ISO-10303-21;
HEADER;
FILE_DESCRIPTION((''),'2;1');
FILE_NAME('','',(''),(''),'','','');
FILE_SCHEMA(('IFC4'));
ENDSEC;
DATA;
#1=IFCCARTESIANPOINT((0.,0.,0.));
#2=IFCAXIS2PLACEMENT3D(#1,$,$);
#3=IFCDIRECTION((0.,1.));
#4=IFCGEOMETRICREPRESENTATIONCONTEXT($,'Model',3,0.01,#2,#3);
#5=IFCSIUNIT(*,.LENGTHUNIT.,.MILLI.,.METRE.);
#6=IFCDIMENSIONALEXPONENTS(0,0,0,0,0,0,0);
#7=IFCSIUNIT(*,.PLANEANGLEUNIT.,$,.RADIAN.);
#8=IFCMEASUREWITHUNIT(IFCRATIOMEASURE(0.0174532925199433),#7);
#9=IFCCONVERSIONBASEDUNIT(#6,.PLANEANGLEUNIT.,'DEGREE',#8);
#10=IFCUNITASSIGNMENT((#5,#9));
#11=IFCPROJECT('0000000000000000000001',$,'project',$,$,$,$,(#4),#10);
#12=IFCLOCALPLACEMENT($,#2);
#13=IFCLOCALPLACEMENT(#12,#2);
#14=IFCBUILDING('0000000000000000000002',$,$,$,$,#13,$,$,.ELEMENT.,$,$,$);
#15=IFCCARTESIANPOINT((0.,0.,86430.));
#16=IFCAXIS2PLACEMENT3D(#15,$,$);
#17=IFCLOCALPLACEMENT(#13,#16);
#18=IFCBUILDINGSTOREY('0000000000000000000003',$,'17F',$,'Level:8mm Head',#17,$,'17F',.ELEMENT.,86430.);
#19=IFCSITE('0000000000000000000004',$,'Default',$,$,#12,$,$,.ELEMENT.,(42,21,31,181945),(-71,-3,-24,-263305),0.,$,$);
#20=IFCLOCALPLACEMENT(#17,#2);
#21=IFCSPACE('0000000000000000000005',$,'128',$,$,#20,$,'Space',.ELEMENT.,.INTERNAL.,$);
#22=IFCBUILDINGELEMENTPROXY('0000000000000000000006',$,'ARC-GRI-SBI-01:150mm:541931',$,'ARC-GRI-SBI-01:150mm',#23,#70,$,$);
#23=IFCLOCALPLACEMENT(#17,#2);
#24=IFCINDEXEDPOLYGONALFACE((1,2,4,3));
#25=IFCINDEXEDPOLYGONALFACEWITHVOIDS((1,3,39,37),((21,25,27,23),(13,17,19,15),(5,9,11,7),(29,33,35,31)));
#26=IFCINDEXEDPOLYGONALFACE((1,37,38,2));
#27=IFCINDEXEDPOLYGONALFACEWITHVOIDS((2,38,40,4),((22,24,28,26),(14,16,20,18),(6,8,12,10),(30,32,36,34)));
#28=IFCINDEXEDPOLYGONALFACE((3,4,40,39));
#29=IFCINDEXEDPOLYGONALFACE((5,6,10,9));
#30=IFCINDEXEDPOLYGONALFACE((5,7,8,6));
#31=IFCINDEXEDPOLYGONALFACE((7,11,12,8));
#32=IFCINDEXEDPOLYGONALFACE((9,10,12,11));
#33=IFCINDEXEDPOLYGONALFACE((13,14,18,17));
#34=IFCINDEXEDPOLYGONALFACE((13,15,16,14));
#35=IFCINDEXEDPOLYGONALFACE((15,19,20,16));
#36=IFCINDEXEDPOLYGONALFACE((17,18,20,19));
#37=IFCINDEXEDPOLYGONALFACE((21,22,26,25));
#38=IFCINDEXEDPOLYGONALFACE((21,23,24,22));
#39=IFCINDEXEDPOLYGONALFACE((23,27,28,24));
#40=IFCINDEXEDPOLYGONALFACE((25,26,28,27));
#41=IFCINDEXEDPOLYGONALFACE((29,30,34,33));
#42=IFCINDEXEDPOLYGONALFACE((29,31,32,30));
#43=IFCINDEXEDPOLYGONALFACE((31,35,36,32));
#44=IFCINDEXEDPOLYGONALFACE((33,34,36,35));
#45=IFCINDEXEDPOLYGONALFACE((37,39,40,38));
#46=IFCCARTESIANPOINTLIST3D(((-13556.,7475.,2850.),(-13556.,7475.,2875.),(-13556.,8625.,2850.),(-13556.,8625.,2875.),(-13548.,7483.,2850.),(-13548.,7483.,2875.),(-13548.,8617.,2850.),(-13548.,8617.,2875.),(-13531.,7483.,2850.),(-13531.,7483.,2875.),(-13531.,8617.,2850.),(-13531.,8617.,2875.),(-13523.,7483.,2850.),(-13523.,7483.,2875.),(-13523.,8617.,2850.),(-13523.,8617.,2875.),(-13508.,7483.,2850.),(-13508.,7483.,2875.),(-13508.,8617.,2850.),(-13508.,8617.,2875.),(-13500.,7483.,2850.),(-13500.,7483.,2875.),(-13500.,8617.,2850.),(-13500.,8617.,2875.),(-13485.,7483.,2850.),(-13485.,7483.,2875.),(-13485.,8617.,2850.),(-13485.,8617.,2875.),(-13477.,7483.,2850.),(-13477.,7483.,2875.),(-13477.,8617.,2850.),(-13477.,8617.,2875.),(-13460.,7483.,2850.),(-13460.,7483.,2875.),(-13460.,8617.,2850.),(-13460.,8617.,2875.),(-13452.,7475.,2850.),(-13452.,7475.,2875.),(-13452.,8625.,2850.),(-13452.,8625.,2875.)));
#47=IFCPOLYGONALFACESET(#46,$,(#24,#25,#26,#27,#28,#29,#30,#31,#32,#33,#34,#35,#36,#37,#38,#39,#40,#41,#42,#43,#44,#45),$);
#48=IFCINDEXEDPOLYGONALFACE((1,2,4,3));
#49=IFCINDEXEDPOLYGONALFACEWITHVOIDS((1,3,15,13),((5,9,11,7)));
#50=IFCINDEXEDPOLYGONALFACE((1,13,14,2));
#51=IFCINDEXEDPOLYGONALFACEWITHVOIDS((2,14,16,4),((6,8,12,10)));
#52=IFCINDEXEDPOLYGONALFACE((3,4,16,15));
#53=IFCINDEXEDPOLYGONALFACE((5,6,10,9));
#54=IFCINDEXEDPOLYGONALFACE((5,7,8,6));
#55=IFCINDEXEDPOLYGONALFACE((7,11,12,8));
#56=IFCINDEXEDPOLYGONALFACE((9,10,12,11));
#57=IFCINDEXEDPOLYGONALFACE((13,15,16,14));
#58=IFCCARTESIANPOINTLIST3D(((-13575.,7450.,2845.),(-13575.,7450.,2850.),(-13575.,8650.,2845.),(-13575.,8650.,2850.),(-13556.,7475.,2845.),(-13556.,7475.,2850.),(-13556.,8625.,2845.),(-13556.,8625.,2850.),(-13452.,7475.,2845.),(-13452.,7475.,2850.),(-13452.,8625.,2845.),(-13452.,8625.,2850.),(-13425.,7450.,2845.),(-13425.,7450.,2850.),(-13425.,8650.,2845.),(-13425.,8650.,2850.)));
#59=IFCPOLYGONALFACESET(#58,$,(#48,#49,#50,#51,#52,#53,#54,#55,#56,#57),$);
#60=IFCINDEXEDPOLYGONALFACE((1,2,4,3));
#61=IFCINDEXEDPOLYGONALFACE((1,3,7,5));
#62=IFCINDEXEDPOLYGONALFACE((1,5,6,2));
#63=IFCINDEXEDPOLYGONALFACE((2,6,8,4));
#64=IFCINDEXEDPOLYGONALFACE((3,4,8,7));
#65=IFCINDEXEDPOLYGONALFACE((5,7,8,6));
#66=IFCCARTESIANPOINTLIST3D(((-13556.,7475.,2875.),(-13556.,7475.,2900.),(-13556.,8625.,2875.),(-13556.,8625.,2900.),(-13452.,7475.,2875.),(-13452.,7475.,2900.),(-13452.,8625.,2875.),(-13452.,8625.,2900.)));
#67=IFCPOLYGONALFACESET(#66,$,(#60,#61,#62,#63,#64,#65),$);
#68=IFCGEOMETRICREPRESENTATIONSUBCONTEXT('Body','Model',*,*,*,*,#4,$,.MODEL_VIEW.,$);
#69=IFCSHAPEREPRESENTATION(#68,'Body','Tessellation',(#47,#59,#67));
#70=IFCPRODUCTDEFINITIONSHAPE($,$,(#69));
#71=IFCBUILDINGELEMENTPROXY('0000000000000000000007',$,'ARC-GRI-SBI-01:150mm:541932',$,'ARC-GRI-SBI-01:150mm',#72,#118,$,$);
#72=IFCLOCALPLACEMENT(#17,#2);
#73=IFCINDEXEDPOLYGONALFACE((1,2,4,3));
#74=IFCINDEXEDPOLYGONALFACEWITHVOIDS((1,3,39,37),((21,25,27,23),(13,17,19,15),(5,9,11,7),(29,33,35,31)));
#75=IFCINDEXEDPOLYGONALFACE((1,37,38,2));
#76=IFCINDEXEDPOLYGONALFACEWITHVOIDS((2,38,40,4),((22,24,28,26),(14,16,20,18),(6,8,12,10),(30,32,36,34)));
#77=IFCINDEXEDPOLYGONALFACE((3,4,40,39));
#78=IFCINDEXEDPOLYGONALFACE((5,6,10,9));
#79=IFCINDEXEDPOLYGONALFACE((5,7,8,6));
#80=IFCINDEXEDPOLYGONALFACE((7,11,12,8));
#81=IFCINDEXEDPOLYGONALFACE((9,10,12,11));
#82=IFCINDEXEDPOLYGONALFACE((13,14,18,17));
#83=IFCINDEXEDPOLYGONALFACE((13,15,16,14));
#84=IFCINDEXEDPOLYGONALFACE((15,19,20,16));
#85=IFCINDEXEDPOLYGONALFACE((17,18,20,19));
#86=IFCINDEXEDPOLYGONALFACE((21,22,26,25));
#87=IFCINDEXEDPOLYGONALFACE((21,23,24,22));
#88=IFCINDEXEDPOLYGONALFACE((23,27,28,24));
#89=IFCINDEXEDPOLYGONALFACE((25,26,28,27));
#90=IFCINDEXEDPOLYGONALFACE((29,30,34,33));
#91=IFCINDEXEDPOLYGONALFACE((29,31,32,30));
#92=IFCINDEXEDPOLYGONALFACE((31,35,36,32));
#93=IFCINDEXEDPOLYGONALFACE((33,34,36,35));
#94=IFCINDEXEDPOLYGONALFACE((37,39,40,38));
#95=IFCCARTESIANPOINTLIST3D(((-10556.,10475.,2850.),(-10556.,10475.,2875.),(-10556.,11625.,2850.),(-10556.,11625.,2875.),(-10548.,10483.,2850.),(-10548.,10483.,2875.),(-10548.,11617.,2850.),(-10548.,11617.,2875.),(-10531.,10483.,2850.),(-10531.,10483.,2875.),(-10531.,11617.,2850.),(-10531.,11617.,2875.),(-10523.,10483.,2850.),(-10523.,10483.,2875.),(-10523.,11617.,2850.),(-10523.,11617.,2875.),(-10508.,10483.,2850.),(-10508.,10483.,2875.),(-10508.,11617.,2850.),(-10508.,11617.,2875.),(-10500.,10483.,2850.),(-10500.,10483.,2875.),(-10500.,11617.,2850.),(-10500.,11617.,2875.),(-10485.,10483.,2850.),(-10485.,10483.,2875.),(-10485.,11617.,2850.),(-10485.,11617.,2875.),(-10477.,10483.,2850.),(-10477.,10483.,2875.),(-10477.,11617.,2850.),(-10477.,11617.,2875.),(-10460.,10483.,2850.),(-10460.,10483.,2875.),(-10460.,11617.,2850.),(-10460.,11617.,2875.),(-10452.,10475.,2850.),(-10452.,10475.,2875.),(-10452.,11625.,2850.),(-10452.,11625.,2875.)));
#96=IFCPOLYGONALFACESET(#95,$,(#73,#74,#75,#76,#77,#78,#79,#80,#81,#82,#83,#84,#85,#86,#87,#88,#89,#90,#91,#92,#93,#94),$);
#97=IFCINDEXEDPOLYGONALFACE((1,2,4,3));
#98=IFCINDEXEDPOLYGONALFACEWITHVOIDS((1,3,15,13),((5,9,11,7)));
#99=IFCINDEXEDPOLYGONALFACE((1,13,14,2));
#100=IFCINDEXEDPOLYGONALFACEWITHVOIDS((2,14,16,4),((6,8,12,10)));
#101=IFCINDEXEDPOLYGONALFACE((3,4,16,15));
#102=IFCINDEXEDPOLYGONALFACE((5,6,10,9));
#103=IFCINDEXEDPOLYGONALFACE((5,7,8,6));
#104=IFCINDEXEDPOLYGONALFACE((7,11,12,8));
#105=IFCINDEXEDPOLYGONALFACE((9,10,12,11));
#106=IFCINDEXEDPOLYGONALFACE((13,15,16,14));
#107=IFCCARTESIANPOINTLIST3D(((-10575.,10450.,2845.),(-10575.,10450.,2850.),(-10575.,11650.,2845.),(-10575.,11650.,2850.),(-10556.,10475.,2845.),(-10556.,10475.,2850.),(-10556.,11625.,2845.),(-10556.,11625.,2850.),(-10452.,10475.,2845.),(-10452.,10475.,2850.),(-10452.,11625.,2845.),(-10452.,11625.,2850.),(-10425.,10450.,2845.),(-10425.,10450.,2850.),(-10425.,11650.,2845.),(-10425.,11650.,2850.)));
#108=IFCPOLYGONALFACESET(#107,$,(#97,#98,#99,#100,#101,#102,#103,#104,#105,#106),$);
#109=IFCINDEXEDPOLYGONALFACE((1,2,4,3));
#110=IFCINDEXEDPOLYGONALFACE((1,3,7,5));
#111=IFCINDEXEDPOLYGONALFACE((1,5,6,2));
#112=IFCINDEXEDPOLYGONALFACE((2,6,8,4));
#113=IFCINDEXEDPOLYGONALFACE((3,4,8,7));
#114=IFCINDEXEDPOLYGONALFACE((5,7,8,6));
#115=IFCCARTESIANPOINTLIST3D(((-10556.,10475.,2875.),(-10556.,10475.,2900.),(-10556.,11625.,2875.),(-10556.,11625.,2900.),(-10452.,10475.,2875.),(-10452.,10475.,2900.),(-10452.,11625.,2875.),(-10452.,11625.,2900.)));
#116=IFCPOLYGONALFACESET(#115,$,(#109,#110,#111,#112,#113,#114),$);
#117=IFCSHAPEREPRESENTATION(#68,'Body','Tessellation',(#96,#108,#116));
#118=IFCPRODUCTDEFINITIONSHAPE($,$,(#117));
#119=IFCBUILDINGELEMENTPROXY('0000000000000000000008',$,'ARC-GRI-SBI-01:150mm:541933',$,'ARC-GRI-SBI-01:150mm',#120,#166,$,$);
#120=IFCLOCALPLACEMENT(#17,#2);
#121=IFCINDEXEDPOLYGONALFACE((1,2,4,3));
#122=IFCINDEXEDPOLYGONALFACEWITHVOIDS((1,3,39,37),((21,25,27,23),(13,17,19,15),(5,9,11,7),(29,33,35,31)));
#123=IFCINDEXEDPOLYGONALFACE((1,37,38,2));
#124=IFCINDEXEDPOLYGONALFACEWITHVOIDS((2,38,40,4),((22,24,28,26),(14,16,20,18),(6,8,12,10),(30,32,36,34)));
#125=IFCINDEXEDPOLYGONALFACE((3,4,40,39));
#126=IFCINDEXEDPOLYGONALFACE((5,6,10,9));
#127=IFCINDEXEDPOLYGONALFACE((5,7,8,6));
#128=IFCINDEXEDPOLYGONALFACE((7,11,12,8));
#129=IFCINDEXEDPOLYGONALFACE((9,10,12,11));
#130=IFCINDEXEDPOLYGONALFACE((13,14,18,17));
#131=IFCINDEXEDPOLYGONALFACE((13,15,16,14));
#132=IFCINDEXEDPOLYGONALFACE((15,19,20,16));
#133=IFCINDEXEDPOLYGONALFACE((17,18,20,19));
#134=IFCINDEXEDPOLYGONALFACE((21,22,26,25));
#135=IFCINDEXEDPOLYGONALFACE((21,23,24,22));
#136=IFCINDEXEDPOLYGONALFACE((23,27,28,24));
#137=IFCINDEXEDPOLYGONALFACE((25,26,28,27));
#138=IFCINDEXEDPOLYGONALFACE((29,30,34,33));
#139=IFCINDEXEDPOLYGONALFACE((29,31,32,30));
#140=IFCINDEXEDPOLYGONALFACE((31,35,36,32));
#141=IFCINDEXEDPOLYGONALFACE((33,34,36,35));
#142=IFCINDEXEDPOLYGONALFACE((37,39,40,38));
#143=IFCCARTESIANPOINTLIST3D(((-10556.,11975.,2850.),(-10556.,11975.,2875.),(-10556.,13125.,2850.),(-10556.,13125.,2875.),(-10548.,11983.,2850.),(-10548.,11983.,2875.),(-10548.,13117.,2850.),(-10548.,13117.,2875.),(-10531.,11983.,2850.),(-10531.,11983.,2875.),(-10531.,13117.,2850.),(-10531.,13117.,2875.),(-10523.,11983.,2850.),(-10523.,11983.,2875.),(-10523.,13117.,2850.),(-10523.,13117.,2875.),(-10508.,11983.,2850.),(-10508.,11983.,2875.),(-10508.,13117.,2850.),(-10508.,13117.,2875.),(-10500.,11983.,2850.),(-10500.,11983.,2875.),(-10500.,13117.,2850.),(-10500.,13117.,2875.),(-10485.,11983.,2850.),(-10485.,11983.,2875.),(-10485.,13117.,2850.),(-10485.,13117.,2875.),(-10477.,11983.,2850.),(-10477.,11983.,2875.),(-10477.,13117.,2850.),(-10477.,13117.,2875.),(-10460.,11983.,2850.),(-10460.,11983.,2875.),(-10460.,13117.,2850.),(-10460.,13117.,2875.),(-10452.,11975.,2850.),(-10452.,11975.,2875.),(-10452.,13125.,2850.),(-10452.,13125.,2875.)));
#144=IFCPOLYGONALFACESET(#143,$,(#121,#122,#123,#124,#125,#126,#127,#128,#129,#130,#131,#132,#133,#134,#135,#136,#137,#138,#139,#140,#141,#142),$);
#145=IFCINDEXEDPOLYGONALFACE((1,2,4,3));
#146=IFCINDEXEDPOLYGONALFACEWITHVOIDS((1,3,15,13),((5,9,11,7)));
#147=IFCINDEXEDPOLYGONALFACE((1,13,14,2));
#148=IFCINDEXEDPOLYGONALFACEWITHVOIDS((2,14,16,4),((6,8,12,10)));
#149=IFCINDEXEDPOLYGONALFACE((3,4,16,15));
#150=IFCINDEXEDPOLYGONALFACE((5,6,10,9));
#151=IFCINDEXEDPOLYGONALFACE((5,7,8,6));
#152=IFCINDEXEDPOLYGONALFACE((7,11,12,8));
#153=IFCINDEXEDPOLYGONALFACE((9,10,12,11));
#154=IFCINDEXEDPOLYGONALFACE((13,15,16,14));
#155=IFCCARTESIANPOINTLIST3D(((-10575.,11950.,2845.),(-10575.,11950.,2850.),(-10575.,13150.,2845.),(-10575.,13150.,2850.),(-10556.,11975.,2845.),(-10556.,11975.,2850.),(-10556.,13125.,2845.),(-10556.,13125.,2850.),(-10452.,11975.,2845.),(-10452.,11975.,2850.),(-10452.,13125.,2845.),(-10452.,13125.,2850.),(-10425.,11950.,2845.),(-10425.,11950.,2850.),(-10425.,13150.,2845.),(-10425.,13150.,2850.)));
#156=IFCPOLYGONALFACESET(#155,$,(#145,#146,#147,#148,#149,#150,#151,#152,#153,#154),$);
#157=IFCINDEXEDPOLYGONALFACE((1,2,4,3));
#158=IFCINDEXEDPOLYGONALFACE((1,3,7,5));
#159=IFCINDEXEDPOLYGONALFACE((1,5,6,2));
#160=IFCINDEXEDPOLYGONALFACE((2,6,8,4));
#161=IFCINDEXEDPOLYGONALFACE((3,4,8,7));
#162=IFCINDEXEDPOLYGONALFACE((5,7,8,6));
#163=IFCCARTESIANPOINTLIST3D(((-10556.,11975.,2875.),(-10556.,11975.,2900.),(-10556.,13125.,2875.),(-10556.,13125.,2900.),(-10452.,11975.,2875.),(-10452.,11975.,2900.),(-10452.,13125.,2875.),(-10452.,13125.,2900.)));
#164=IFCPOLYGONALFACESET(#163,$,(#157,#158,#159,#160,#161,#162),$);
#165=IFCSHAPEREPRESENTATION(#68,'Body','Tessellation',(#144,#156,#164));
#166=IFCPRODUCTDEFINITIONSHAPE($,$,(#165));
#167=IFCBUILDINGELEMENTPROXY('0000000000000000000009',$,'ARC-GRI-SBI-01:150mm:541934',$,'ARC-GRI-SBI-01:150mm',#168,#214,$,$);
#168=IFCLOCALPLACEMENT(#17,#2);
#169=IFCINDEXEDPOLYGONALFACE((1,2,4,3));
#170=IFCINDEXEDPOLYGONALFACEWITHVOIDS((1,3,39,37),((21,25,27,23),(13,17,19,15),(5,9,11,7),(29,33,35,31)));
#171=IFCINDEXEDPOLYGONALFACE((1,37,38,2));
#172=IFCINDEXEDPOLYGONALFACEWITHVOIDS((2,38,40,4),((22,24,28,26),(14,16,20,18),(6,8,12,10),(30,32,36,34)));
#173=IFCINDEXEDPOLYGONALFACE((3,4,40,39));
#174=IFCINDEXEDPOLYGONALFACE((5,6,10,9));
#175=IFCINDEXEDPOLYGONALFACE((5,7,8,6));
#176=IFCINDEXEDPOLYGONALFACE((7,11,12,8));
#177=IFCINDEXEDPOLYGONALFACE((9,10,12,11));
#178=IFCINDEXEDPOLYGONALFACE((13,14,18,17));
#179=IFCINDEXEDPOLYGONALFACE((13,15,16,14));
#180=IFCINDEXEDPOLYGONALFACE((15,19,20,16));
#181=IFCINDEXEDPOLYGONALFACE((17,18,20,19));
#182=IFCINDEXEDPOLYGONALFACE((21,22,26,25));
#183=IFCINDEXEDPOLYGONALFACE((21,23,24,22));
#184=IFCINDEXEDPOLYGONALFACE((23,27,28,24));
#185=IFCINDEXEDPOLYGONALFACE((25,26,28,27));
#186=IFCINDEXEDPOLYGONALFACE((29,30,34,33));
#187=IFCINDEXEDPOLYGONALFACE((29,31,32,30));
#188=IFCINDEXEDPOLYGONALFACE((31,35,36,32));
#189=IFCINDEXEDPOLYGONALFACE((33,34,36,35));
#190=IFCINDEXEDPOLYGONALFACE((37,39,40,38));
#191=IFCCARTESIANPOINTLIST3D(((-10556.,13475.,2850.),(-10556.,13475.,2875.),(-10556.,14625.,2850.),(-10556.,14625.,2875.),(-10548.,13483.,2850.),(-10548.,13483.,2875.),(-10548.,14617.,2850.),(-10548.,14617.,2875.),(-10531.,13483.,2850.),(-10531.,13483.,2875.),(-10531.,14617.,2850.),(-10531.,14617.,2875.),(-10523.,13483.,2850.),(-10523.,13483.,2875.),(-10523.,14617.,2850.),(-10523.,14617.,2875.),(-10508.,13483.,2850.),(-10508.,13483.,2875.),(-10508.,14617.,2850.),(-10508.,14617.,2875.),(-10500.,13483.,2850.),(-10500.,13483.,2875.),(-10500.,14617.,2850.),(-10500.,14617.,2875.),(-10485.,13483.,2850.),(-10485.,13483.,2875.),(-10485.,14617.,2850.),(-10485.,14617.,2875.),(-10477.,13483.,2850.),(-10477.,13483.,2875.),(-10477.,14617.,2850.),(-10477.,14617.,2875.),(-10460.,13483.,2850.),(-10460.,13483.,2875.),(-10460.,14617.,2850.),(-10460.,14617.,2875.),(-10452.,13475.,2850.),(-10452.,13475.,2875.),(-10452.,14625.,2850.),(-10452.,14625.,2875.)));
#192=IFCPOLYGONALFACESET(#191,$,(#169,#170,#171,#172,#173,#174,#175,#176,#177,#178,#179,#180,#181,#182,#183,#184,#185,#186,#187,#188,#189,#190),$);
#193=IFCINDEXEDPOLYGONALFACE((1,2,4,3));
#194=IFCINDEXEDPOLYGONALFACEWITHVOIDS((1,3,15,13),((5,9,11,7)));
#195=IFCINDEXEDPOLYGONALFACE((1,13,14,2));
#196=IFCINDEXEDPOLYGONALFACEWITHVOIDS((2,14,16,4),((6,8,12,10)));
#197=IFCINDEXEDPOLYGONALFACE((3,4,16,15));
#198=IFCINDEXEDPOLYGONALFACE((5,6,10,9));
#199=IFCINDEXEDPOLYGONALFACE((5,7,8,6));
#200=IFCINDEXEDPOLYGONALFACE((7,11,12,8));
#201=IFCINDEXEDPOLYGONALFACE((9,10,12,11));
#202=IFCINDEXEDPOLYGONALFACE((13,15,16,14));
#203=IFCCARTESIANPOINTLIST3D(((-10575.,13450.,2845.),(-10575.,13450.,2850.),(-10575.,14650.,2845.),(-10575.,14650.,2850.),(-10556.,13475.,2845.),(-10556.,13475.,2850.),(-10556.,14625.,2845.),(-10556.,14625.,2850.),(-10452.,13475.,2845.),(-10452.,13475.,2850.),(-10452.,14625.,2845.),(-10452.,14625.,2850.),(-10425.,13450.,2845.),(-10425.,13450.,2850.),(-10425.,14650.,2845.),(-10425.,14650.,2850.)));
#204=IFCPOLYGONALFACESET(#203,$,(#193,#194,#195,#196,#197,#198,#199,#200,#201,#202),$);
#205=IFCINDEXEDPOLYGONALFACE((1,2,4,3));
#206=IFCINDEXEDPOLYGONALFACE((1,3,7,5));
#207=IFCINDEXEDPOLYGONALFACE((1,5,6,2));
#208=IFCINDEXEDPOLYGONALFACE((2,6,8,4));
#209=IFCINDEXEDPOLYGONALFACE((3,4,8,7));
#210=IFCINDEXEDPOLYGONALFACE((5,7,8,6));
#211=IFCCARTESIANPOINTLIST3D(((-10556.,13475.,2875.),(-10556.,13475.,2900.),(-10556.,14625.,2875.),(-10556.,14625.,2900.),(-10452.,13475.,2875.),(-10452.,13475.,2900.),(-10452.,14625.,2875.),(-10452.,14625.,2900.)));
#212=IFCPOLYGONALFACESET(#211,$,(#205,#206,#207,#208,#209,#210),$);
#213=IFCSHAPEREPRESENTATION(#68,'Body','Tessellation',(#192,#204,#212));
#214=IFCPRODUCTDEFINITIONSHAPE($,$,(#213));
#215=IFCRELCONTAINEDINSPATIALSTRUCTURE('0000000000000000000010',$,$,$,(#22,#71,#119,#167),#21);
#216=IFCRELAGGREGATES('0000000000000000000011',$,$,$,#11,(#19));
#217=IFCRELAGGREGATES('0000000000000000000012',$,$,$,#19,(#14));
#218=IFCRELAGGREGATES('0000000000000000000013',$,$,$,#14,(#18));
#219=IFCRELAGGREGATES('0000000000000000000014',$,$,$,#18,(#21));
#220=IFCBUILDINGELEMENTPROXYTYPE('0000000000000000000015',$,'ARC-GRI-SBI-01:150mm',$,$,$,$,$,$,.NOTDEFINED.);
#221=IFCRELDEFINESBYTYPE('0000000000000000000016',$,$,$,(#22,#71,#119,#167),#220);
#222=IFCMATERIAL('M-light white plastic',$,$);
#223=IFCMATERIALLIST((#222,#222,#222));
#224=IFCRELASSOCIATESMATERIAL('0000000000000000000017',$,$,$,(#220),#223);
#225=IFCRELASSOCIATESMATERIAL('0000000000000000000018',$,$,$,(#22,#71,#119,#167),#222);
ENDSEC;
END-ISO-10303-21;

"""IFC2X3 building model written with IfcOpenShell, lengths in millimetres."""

from ifc_helpers import new_model, entity, si_unit, converted_unit, direction, frame, origin, origin_2d_with_axis, place, context, subcontext, project, spatial, polyline, rectangle, outline, extrude, source, transform, mapped, material, material_list, type_object, type_shapes, element, save


model = new_model("IFC2X3")

# Units and contexts
model_context = context("Model", 3, precision=0.01, world=origin(), true_north=direction((0.0, 1.0)))
body_context = subcontext(model_context, "Body", "Model", "MODEL_VIEW")
ifc_project = project(units=[si_unit("LENGTHUNIT", "METRE", prefix="MILLI"), converted_unit("PLANEANGLEUNIT", "DEGREE", entity("IfcRatioMeasure", 0.0174532925199433), si_unit("PLANEANGLEUNIT", "RADIAN"), dimensions=[0, 0, 0, 0, 0, 0, 0])], contexts=[model_context])

# Site, building, storey, space
site_placement = place(None, origin())
site = spatial("IfcSite", under=ifc_project, at=site_placement, Name="Default", CompositionType="ELEMENT", RefLatitude=(42, 21, 31, 181945), RefLongitude=(-71, -3, -24, -263305), RefElevation=0.0)
building_placement = place(site_placement, origin())
building = spatial("IfcBuilding", under=site, at=building_placement, CompositionType="ELEMENT")
storey_placement = place(building_placement, frame((0.0, 0.0, 86430.0)))
storey = spatial("IfcBuildingStorey", under=building, at=storey_placement, Name="17F", ObjectType="Level:8mm Head", LongName="17F", CompositionType="ELEMENT", Elevation=86430.0)
space_placement = place(storey_placement, origin())
space = spatial("IfcSpace", under=storey, at=space_placement, Name="128", LongName="Space", CompositionType="ELEMENT", InteriorOrExteriorSpace="INTERNAL")

# Shared definitions
ifc_material_1 = material(Name="M-light white plastic")

# Building element proxies
ifc_material_list_1 = material_list([ifc_material_1, ifc_material_1, ifc_material_1])
building_element_proxy_type = type_object("IfcBuildingElementProxyType", Name="ARC-GRI-SBI-01:150mm", PredefinedType="NOTDEFINED", material=ifc_material_list_1)
shared_shape_1 = source(origin(), body_context, "Body", "SweptSolid", [
    extrude(outline(polyline([(-575.0, -52.0), (575.0, -52.0), (575.0, 52.0), (-575.0, 52.0), (-575.0, -52.0)]), holes=[polyline([(-567.0, -44.0), (-567.0, -27.0), (567.0, -27.0), (567.0, -44.0), (-567.0, -44.0)]), polyline([(567.0, -4.0), (567.0, -19.0), (-567.0, -19.0), (-567.0, -4.0), (567.0, -4.0)]), polyline([(-567.0, 44.0), (567.0, 44.0), (567.0, 27.0), (-567.0, 27.0), (-567.0, 44.0)]), polyline([(567.0, 4.0), (-567.0, 4.0), (-567.0, 19.0), (567.0, 19.0), (567.0, 4.0)])]), frame((425.0, 4.0, 4000.0), z_axis=(0.0, 0.0, 1.0), x_axis=(-1.0, 0.0, 0.0)), (0.0, 0.0, 1.0), 25.0),
    extrude(outline(polyline([(-600.0, -75.0), (600.0, -75.0), (600.0, 75.0), (-600.0, 75.0), (-600.0, -75.0)]), holes=[polyline([(-575.0, -56.0), (-575.0, 48.0), (575.0, 48.0), (575.0, -56.0), (-575.0, -56.0)])]), frame((425.0, 0.0, 3995.0), z_axis=(0.0, 0.0, 1.0), x_axis=(-1.0, 0.0, 0.0)), (0.0, 0.0, 1.0), 5.0),
    extrude(rectangle(XDim=1150.0, YDim=104.0, at=origin_2d_with_axis()), frame((425.0, 4.0, 4025.0), z_axis=(0.0, 0.0, 1.0), x_axis=(-1.0, 0.0, 0.0)), (0.0, 0.0, 1.0), 25.0),
])
type_shapes(building_element_proxy_type, [shared_shape_1])
for number, where, z_axis, x_axis, name in (
    (1, (-13500.0, 7625.0, -1150.0), (0.0, 0.0, 1.0), (0.0, 1.0, 0.0), "ARC-GRI-SBI-01:150mm:541931"),
    (2, (-10500.0, 10625.0, -1150.0), (0.0, 0.0, 1.0), (0.0, 1.0, 0.0), "ARC-GRI-SBI-01:150mm:541932"),
    (3, (-10500.0, 12125.0, -1150.0), (0.0, 0.0, 1.0), (0.0, 1.0, 0.0), "ARC-GRI-SBI-01:150mm:541933"),
    (4, (-10500.0, 13625.0, -1150.0), (0.0, 0.0, 1.0), (0.0, 1.0, 0.0), "ARC-GRI-SBI-01:150mm:541934"),
):
    element("IfcBuildingElementProxy", number, at=place(space_placement, frame(where, z_axis=z_axis, x_axis=x_axis)), inside=space, type_object=building_element_proxy_type, material=ifc_material_1, Name=name, ObjectType="ARC-GRI-SBI-01:150mm", context=body_context, shape_type="MappedRepresentation", body=[
        mapped(shared_shape_1, transform((0.0, 0.0, 0.0), scale=1.0)),
    ])

save(model, "model.ifc")
